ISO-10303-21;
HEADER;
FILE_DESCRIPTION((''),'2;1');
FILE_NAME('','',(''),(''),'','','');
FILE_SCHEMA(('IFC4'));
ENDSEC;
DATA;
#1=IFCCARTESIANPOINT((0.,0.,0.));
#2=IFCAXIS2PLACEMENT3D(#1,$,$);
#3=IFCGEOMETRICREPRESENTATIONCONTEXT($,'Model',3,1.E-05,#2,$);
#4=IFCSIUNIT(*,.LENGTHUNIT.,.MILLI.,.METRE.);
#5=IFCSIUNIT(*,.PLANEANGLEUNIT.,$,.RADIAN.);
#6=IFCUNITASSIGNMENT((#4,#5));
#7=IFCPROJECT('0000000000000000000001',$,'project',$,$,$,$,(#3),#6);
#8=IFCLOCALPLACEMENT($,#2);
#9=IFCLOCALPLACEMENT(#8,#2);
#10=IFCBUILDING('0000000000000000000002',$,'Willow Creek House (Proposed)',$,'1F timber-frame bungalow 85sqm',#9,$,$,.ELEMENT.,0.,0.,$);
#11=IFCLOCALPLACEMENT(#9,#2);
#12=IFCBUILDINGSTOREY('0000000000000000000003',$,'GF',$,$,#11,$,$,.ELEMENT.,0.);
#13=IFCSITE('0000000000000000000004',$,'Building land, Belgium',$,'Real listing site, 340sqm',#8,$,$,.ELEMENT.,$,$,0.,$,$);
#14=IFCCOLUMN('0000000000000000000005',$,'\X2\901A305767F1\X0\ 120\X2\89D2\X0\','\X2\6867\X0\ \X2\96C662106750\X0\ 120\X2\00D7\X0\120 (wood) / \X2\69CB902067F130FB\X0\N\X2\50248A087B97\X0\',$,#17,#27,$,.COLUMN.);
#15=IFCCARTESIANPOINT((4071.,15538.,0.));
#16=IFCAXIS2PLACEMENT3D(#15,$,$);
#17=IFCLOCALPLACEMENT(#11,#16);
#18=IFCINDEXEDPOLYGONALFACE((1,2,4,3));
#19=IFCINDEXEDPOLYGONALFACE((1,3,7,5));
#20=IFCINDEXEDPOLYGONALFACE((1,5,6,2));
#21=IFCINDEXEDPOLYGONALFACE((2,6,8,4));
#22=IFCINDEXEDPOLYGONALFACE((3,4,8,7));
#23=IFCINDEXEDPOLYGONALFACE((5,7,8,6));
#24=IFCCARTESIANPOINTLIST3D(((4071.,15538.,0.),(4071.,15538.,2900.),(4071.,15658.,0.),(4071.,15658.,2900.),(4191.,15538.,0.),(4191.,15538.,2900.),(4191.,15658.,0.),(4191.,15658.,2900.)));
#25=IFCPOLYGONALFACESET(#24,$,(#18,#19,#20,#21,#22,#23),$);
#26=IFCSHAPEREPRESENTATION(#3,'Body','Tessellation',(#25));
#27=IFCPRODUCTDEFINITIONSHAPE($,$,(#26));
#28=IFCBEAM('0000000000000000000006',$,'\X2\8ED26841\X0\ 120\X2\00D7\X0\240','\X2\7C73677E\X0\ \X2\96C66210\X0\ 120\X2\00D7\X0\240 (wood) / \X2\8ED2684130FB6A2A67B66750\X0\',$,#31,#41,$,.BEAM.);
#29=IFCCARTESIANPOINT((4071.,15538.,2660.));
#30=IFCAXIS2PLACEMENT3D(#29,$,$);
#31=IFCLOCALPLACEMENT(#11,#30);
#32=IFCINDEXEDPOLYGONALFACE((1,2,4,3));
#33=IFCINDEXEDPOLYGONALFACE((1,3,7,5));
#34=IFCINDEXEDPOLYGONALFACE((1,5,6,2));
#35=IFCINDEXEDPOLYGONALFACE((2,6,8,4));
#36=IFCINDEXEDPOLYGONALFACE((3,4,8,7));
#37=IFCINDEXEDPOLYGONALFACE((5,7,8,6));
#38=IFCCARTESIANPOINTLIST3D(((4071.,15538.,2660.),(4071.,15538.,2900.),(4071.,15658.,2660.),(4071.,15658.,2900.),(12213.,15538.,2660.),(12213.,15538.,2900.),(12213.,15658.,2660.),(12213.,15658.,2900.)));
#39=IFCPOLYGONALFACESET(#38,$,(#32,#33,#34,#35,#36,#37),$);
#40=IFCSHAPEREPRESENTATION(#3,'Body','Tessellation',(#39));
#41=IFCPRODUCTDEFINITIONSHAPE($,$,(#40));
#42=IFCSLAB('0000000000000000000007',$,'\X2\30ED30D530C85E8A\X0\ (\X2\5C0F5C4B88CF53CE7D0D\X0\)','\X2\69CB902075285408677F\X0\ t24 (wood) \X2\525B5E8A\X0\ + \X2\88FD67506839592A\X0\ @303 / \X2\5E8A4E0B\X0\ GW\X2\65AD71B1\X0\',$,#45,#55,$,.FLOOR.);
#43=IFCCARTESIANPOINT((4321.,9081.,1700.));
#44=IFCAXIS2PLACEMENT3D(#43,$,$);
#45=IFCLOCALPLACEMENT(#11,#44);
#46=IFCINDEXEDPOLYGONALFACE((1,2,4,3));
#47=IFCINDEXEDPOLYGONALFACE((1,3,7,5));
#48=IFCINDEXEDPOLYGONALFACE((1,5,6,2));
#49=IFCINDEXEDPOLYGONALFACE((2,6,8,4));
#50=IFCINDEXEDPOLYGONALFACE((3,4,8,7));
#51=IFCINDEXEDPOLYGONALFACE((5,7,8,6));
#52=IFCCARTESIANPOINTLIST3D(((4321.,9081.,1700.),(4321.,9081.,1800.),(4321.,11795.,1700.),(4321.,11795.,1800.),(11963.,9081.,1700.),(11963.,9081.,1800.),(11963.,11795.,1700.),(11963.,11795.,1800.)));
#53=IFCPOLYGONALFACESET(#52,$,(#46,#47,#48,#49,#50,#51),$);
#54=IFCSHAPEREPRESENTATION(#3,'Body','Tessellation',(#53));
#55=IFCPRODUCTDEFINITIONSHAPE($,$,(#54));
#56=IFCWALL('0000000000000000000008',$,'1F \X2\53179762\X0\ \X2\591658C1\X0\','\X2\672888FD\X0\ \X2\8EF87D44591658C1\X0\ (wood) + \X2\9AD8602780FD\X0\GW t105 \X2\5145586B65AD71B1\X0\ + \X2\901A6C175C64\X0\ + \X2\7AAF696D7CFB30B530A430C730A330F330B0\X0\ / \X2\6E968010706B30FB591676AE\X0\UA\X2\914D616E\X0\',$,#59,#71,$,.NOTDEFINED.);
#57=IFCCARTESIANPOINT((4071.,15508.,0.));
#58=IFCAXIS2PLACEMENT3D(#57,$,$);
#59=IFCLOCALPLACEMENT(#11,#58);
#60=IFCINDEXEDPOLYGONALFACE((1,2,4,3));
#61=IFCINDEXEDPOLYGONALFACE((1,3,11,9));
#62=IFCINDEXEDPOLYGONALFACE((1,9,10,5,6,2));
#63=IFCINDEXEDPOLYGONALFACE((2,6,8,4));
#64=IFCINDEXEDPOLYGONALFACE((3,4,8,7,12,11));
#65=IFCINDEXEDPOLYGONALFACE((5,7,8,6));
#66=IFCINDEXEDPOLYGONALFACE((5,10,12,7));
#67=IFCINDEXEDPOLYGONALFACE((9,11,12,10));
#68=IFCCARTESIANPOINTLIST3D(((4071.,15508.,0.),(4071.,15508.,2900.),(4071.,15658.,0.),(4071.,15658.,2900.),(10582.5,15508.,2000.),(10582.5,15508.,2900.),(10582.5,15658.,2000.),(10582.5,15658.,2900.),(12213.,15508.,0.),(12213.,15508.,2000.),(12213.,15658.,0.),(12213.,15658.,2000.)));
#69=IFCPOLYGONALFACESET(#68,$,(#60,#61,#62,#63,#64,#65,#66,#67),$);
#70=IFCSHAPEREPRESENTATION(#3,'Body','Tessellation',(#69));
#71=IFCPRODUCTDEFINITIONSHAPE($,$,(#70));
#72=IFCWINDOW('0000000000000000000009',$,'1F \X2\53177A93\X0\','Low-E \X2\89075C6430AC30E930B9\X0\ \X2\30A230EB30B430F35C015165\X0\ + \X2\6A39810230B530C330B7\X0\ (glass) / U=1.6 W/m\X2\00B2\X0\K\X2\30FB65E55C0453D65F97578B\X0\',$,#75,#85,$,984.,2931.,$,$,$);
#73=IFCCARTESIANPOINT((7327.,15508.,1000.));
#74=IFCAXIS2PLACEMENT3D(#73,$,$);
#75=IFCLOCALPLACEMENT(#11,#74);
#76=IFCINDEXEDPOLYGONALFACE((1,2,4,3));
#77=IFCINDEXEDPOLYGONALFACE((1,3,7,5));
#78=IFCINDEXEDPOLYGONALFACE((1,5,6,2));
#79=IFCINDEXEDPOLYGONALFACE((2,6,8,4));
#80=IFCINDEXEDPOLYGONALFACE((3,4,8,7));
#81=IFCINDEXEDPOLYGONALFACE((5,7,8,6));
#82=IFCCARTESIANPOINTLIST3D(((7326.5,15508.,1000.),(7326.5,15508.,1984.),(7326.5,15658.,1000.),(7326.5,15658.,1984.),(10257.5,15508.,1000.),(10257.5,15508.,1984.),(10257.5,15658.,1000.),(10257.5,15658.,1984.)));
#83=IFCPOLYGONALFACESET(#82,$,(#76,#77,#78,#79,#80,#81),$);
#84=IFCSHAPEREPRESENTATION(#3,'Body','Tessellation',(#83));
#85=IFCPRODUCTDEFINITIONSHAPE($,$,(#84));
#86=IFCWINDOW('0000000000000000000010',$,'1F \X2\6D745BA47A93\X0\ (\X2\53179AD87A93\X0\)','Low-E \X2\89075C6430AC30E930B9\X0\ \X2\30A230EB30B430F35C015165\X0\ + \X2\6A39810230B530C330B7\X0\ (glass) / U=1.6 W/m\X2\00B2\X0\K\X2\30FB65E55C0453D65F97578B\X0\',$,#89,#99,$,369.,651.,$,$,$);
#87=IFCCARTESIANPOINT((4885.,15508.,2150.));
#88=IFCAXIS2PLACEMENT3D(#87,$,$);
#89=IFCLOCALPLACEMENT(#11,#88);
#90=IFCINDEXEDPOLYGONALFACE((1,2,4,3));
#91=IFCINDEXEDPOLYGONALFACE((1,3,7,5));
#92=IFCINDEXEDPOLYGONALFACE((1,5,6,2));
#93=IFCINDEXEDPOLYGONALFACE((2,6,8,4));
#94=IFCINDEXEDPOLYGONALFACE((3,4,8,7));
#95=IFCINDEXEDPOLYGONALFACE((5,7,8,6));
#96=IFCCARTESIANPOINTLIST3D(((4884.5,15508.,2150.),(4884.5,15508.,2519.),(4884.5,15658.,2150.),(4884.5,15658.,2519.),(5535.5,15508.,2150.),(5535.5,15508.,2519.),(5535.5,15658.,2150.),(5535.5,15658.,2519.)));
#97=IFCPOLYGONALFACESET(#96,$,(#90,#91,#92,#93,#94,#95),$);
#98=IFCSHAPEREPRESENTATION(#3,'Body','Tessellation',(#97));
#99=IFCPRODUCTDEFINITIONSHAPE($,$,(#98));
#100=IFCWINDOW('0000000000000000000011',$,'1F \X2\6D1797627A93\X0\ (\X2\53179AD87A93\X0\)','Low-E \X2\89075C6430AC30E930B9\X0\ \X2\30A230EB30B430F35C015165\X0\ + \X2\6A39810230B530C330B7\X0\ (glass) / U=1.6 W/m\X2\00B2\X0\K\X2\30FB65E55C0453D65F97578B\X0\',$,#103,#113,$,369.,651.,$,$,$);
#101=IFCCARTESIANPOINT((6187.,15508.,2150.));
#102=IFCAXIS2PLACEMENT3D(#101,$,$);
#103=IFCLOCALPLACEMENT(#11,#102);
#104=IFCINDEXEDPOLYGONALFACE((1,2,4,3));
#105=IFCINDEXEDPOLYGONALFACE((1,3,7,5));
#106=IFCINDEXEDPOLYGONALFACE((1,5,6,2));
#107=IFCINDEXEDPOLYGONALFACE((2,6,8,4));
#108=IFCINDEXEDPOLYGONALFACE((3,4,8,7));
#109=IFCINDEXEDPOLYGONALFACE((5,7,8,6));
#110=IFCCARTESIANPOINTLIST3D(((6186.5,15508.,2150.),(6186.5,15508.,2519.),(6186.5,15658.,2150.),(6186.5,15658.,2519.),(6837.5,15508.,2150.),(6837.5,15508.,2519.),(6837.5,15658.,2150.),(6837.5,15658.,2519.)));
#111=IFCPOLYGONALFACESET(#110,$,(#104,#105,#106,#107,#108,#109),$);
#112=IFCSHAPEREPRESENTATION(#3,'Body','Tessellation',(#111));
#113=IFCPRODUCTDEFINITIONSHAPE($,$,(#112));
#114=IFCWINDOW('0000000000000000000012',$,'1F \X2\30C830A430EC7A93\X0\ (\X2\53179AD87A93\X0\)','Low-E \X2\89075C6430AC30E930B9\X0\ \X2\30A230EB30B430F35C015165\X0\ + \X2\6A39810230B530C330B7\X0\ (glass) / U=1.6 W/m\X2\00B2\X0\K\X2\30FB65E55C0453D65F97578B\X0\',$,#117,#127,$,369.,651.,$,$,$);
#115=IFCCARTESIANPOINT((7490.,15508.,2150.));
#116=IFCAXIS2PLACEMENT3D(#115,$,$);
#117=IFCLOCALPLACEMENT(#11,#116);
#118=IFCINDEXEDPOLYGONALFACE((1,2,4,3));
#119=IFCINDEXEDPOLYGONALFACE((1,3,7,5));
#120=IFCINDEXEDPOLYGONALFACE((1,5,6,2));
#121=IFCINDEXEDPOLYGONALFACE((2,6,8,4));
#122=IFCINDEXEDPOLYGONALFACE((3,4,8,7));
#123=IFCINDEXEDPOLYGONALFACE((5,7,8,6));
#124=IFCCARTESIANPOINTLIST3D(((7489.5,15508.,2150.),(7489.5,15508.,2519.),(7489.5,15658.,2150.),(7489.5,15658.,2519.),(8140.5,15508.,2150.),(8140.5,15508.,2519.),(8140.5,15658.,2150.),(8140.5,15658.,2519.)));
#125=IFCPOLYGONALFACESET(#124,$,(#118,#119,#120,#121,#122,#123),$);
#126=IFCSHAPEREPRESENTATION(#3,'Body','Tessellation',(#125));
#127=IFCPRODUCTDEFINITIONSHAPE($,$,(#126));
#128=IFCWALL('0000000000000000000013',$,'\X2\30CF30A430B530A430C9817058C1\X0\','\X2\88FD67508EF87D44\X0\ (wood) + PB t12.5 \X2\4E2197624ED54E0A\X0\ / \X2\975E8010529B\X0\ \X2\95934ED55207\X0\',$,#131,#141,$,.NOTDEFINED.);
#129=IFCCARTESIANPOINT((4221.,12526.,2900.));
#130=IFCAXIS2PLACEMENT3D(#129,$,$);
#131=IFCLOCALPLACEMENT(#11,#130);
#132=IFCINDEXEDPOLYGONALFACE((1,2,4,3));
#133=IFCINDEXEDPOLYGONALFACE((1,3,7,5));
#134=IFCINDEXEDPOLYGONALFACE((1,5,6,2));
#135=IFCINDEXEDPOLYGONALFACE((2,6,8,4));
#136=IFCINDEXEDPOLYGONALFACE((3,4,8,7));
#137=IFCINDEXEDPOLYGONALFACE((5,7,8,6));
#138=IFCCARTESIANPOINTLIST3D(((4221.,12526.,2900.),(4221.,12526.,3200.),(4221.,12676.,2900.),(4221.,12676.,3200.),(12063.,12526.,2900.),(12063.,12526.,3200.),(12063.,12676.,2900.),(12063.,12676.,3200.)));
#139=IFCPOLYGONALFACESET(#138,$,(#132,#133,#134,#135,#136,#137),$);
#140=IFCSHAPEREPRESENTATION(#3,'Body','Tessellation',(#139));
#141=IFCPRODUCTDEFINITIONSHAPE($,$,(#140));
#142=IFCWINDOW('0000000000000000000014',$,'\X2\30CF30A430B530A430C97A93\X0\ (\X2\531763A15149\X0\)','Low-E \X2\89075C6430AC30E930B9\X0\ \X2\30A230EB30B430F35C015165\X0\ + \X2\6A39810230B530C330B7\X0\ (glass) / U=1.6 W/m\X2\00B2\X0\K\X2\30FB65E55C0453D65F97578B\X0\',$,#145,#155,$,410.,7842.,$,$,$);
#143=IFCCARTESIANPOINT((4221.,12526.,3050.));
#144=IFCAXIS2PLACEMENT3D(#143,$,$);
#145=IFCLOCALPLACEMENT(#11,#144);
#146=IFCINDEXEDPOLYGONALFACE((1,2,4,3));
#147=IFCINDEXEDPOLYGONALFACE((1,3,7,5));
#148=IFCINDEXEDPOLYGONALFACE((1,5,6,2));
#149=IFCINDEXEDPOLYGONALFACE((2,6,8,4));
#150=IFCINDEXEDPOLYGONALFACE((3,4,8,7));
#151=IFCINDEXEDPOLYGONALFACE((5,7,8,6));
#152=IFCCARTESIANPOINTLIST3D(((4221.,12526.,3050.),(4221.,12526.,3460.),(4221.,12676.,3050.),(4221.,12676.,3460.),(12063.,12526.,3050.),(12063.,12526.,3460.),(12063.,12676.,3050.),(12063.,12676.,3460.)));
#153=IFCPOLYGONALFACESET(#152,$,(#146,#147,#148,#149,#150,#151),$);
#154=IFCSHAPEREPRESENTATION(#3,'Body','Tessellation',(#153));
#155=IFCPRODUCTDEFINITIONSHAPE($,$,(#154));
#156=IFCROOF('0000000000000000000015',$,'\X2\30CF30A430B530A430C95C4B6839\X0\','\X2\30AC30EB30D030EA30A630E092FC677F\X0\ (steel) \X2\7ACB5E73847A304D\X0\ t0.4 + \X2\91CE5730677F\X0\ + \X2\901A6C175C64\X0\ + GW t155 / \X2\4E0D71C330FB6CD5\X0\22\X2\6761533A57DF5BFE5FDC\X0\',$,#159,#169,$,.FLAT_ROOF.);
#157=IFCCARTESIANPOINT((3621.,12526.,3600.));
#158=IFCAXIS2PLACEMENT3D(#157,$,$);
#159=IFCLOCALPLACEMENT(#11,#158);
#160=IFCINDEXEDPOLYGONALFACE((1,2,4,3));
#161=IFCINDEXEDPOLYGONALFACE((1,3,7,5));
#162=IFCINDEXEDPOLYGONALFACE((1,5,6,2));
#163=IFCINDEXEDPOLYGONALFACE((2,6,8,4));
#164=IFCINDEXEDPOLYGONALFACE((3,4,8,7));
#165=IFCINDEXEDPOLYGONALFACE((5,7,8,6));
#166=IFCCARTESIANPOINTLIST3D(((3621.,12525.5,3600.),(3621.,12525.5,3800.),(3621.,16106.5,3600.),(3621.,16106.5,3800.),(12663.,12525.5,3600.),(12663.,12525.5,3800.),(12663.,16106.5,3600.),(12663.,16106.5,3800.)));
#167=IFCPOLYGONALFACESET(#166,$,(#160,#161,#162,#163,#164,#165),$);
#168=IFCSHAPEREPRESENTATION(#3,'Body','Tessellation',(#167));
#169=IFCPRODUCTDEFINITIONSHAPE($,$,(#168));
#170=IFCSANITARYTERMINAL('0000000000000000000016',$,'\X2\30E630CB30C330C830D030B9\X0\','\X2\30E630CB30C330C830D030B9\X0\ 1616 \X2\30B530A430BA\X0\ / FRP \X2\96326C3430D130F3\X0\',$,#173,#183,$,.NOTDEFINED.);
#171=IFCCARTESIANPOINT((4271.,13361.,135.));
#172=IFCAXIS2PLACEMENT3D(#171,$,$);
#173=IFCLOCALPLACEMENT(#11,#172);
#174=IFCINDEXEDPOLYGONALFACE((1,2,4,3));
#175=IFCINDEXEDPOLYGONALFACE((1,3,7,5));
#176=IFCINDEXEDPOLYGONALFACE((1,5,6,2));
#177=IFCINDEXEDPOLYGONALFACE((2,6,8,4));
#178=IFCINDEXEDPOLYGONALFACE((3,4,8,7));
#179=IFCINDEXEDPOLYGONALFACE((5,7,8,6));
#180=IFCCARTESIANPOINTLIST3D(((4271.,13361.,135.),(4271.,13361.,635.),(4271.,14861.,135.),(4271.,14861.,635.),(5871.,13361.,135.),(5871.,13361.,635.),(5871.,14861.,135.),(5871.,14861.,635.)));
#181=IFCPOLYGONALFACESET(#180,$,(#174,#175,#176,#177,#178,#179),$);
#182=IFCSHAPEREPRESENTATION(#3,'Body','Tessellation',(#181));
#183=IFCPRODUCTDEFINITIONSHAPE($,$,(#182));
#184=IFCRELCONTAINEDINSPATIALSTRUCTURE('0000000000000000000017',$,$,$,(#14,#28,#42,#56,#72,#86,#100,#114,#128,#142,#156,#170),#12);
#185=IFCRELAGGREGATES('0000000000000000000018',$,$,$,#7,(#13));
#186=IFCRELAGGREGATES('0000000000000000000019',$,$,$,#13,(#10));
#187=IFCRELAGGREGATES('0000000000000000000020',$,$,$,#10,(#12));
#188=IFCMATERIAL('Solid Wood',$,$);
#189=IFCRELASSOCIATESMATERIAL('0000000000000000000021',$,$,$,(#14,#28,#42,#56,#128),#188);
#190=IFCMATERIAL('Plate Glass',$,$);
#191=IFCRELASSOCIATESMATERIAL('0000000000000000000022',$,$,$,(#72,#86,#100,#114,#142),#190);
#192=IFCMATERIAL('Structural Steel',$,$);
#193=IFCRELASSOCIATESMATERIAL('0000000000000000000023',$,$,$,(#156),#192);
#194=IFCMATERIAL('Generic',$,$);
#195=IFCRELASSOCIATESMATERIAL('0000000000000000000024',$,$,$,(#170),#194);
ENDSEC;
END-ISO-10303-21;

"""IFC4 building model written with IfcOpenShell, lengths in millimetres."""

from ifc_helpers import new_model, si_unit, frame, frame_2d, origin, place, context, project, spatial, rectangle, extrude, material, element, fill, save


model = new_model("IFC4")

# Units and contexts
model_context = context("Model", 3, precision=1e-05, world=origin())
ifc_project = project(units=[si_unit("LENGTHUNIT", "METRE", prefix="MILLI"), si_unit("PLANEANGLEUNIT", "RADIAN")], contexts=[model_context])

# Site, building, storey
site_placement = place(None, origin())
site = spatial("IfcSite", under=ifc_project, at=site_placement, Name="Building land, Belgium", ObjectType="Real listing site, 340sqm", CompositionType="ELEMENT", RefElevation=0.0)
building_placement = place(site_placement, origin())
building = spatial("IfcBuilding", under=site, at=building_placement, Name="Willow Creek House (Proposed)", ObjectType="1F timber-frame bungalow 85sqm", CompositionType="ELEMENT", ElevationOfRefHeight=0.0, ElevationOfTerrain=0.0)
storey_placement = place(building_placement, origin())
storey = spatial("IfcBuildingStorey", under=building, at=storey_placement, Name="GF", CompositionType="ELEMENT", Elevation=0.0)

# Column
ifc_material_1 = material(Name="Solid Wood")
column_1_placement = place(storey_placement, frame((4071.0, 15538.0, 0.0)))
element("IfcColumn", 1, at=column_1_placement, inside=storey, material=ifc_material_1, Name="通し柱 120角", Description="桧 集成材 120×120 (wood) / 構造柱・N値計算", PredefinedType="COLUMN", context=model_context, shape_type="SweptSolid", body=[
    extrude(rectangle(XDim=120.0, YDim=120.0, at=frame_2d((60.0, 60.0))), frame((4071.0, 15538.0, 0.0)), (0.0, 0.0, 1.0), 2900.0),
])

# Beam
beam_1_placement = place(storey_placement, frame((4071.0, 15538.0, 2660.0)))
element("IfcBeam", 2, at=beam_1_placement, inside=storey, material=ifc_material_1, Name="軒桁 120×240", Description="米松 集成 120×240 (wood) / 軒桁・横架材", PredefinedType="BEAM", context=model_context, shape_type="SweptSolid", body=[
    extrude(rectangle(XDim=8142.0, YDim=120.0, at=frame_2d((4071.0, 60.0))), frame((4071.0, 15538.0, 2660.0)), (0.0, 0.0, 1.0), 240.0),
])

# Slab
slab_placement = place(storey_placement, frame((4321.0, 9081.0, 1700.0)))
element("IfcSlab", 3, at=slab_placement, inside=storey, material=ifc_material_1, Name="ロフト床 (小屋裏収納)", Description="構造用合板 t24 (wood) 剛床 + 製材根太 @303 / 床下 GW断熱", PredefinedType="FLOOR", context=model_context, shape_type="SweptSolid", body=[
    extrude(rectangle(XDim=7642.0, YDim=2714.0, at=frame_2d((3821.0, 1357.0))), frame((4321.0, 9081.0, 1700.0)), (0.0, 0.0, 1.0), 100.0),
])

# Wall, openings, windows
wall_1_placement = place(storey_placement, frame((4071.0, 15508.0, 0.0)))
wall_1 = element("IfcWall", 4, at=wall_1_placement, inside=storey, material=ifc_material_1, Name="1F 北面 外壁", Description="木製 軸組外壁 (wood) + 高性能GW t105 充填断熱 + 通気層 + 窯業系サイディング / 準耐火・外皮UA配慮", PredefinedType="NOTDEFINED", context=model_context, shape_type="SweptSolid", body=[
    extrude(rectangle(XDim=8142.0, YDim=150.0, at=frame_2d((4071.0, 75.0))), frame((4071.0, 15508.0, 0.0)), (0.0, 0.0, 1.0), 2900.0),
])
opening_1_placement = place(storey_placement, frame((7327.0, 15508.0, 1000.0)))
opening_1 = element("IfcOpeningElement", 5, at=opening_1_placement, cuts=wall_1, PredefinedType="NOTDEFINED", context=model_context, shape_type="SweptSolid", body=[
    extrude(rectangle(XDim=2931.0, YDim=150.0, at=frame_2d((1465.0, 75.0))), frame((7327.0, 15508.0, 1000.0)), (0.0, 0.0, 1.0), 984.0),
])
opening_2_placement = place(storey_placement, frame((4885.0, 15508.0, 2150.0)))
opening_2 = element("IfcOpeningElement", 6, at=opening_2_placement, cuts=wall_1, PredefinedType="NOTDEFINED", context=model_context, shape_type="SweptSolid", body=[
    extrude(rectangle(XDim=651.0, YDim=150.0, at=frame_2d((325.0, 75.0))), frame((4885.0, 15508.0, 2150.0)), (0.0, 0.0, 1.0), 369.0),
])
opening_3_placement = place(storey_placement, frame((6187.0, 15508.0, 2150.0)))
opening_3 = element("IfcOpeningElement", 7, at=opening_3_placement, cuts=wall_1, PredefinedType="NOTDEFINED", context=model_context, shape_type="SweptSolid", body=[
    extrude(rectangle(XDim=651.0, YDim=150.0, at=frame_2d((325.0, 75.0))), frame((6187.0, 15508.0, 2150.0)), (0.0, 0.0, 1.0), 369.0),
])
opening_4_placement = place(storey_placement, frame((7490.0, 15508.0, 2150.0)))
opening_4 = element("IfcOpeningElement", 8, at=opening_4_placement, cuts=wall_1, PredefinedType="NOTDEFINED", context=model_context, shape_type="SweptSolid", body=[
    extrude(rectangle(XDim=651.0, YDim=150.0, at=frame_2d((325.0, 75.0))), frame((7490.0, 15508.0, 2150.0)), (0.0, 0.0, 1.0), 369.0),
])
ifc_material_2 = material(Name="Plate Glass")
window_1_placement = place(storey_placement, frame((7327.0, 15508.0, 1000.0)))
window_1 = element("IfcWindow", 9, at=window_1_placement, inside=storey, material=ifc_material_2, Name="1F 北窓", Description="Low-E 複層ガラス アルゴン封入 + 樹脂サッシ (glass) / U=1.6 W/m²K・日射取得型", OverallHeight=984.0, OverallWidth=2931.0, context=model_context, shape_type="SweptSolid", body=[
    extrude(rectangle(XDim=2931.0, YDim=150.0, at=frame_2d((1465.0, 75.0))), frame((7327.0, 15508.0, 1000.0)), (0.0, 0.0, 1.0), 984.0),
])
fill(opening_1, window_1)
window_2_placement = place(storey_placement, frame((4885.0, 15508.0, 2150.0)))
window_2 = element("IfcWindow", 10, at=window_2_placement, inside=storey, material=ifc_material_2, Name="1F 浴室窓 (北高窓)", Description="Low-E 複層ガラス アルゴン封入 + 樹脂サッシ (glass) / U=1.6 W/m²K・日射取得型", OverallHeight=369.0, OverallWidth=651.0, context=model_context, shape_type="SweptSolid", body=[
    extrude(rectangle(XDim=651.0, YDim=150.0, at=frame_2d((325.0, 75.0))), frame((4885.0, 15508.0, 2150.0)), (0.0, 0.0, 1.0), 369.0),
])
fill(opening_2, window_2)
window_3_placement = place(storey_placement, frame((6187.0, 15508.0, 2150.0)))
window_3 = element("IfcWindow", 11, at=window_3_placement, inside=storey, material=ifc_material_2, Name="1F 洗面窓 (北高窓)", Description="Low-E 複層ガラス アルゴン封入 + 樹脂サッシ (glass) / U=1.6 W/m²K・日射取得型", OverallHeight=369.0, OverallWidth=651.0, context=model_context, shape_type="SweptSolid", body=[
    extrude(rectangle(XDim=651.0, YDim=150.0, at=frame_2d((325.0, 75.0))), frame((6187.0, 15508.0, 2150.0)), (0.0, 0.0, 1.0), 369.0),
])
fill(opening_3, window_3)
window_4_placement = place(storey_placement, frame((7490.0, 15508.0, 2150.0)))
window_4 = element("IfcWindow", 12, at=window_4_placement, inside=storey, material=ifc_material_2, Name="1F トイレ窓 (北高窓)", Description="Low-E 複層ガラス アルゴン封入 + 樹脂サッシ (glass) / U=1.6 W/m²K・日射取得型", OverallHeight=369.0, OverallWidth=651.0, context=model_context, shape_type="SweptSolid", body=[
    extrude(rectangle(XDim=651.0, YDim=150.0, at=frame_2d((325.0, 75.0))), frame((7490.0, 15508.0, 2150.0)), (0.0, 0.0, 1.0), 369.0),
])
fill(opening_4, window_4)

# Wall, opening, window
wall_2_placement = place(storey_placement, frame((4221.0, 12526.0, 2900.0)))
wall_2 = element("IfcWall", 13, at=wall_2_placement, inside=storey, material=ifc_material_1, Name="ハイサイド腰壁", Description="製材軸組 (wood) + PB t12.5 両面仕上 / 非耐力 間仕切", PredefinedType="NOTDEFINED", context=model_context, shape_type="SweptSolid", body=[
    extrude(rectangle(XDim=7842.0, YDim=150.0, at=frame_2d((3921.0, 75.0))), frame((4221.0, 12526.0, 2900.0)), (0.0, 0.0, 1.0), 700.0),
])
opening_5_placement = place(storey_placement, frame((4221.0, 12526.0, 3050.0)))
opening_5 = element("IfcOpeningElement", 14, at=opening_5_placement, cuts=wall_2, PredefinedType="NOTDEFINED", context=model_context, shape_type="SweptSolid", body=[
    extrude(rectangle(XDim=7842.0, YDim=150.0, at=frame_2d((3921.0, 75.0))), frame((4221.0, 12526.0, 3050.0)), (0.0, 0.0, 1.0), 410.0),
])
window_5_placement = place(storey_placement, frame((4221.0, 12526.0, 3050.0)))
window_5 = element("IfcWindow", 15, at=window_5_placement, inside=storey, material=ifc_material_2, Name="ハイサイド窓 (北採光)", Description="Low-E 複層ガラス アルゴン封入 + 樹脂サッシ (glass) / U=1.6 W/m²K・日射取得型", OverallHeight=410.0, OverallWidth=7842.0, context=model_context, shape_type="SweptSolid", body=[
    extrude(rectangle(XDim=7842.0, YDim=150.0, at=frame_2d((3921.0, 75.0))), frame((4221.0, 12526.0, 3050.0)), (0.0, 0.0, 1.0), 410.0),
])
fill(opening_5, window_5)

# Roof
ifc_material_3 = material(Name="Structural Steel")
roof_placement = place(storey_placement, frame((3621.0, 12526.0, 3600.0)))
element("IfcRoof", 16, at=roof_placement, inside=storey, material=ifc_material_3, Name="ハイサイド屋根", Description="ガルバリウム鋼板 (steel) 立平葺き t0.4 + 野地板 + 通気層 + GW t155 / 不燃・法22条区域対応", PredefinedType="FLAT_ROOF", context=model_context, shape_type="SweptSolid", body=[
    extrude(rectangle(XDim=9042.0, YDim=3581.0, at=frame_2d((4521.0, 1790.0))), frame((3621.0, 12526.0, 3600.0)), (0.0, 0.0, 1.0), 200.0),
])

# Sanitary terminal
ifc_material_4 = material(Name="Generic")
sanitary_terminal_placement = place(storey_placement, frame((4271.0, 13361.0, 135.0)))
element("IfcSanitaryTerminal", 17, at=sanitary_terminal_placement, inside=storey, material=ifc_material_4, Name="ユニットバス", Description="ユニットバス 1616 サイズ / FRP 防水パン", PredefinedType="NOTDEFINED", context=model_context, shape_type="SweptSolid", body=[
    extrude(rectangle(XDim=1600.0, YDim=1500.0, at=frame_2d((800.0, 750.0))), frame((4271.0, 13361.0, 135.0)), (0.0, 0.0, 1.0), 500.0),
])

save(model, "model.ifc")
